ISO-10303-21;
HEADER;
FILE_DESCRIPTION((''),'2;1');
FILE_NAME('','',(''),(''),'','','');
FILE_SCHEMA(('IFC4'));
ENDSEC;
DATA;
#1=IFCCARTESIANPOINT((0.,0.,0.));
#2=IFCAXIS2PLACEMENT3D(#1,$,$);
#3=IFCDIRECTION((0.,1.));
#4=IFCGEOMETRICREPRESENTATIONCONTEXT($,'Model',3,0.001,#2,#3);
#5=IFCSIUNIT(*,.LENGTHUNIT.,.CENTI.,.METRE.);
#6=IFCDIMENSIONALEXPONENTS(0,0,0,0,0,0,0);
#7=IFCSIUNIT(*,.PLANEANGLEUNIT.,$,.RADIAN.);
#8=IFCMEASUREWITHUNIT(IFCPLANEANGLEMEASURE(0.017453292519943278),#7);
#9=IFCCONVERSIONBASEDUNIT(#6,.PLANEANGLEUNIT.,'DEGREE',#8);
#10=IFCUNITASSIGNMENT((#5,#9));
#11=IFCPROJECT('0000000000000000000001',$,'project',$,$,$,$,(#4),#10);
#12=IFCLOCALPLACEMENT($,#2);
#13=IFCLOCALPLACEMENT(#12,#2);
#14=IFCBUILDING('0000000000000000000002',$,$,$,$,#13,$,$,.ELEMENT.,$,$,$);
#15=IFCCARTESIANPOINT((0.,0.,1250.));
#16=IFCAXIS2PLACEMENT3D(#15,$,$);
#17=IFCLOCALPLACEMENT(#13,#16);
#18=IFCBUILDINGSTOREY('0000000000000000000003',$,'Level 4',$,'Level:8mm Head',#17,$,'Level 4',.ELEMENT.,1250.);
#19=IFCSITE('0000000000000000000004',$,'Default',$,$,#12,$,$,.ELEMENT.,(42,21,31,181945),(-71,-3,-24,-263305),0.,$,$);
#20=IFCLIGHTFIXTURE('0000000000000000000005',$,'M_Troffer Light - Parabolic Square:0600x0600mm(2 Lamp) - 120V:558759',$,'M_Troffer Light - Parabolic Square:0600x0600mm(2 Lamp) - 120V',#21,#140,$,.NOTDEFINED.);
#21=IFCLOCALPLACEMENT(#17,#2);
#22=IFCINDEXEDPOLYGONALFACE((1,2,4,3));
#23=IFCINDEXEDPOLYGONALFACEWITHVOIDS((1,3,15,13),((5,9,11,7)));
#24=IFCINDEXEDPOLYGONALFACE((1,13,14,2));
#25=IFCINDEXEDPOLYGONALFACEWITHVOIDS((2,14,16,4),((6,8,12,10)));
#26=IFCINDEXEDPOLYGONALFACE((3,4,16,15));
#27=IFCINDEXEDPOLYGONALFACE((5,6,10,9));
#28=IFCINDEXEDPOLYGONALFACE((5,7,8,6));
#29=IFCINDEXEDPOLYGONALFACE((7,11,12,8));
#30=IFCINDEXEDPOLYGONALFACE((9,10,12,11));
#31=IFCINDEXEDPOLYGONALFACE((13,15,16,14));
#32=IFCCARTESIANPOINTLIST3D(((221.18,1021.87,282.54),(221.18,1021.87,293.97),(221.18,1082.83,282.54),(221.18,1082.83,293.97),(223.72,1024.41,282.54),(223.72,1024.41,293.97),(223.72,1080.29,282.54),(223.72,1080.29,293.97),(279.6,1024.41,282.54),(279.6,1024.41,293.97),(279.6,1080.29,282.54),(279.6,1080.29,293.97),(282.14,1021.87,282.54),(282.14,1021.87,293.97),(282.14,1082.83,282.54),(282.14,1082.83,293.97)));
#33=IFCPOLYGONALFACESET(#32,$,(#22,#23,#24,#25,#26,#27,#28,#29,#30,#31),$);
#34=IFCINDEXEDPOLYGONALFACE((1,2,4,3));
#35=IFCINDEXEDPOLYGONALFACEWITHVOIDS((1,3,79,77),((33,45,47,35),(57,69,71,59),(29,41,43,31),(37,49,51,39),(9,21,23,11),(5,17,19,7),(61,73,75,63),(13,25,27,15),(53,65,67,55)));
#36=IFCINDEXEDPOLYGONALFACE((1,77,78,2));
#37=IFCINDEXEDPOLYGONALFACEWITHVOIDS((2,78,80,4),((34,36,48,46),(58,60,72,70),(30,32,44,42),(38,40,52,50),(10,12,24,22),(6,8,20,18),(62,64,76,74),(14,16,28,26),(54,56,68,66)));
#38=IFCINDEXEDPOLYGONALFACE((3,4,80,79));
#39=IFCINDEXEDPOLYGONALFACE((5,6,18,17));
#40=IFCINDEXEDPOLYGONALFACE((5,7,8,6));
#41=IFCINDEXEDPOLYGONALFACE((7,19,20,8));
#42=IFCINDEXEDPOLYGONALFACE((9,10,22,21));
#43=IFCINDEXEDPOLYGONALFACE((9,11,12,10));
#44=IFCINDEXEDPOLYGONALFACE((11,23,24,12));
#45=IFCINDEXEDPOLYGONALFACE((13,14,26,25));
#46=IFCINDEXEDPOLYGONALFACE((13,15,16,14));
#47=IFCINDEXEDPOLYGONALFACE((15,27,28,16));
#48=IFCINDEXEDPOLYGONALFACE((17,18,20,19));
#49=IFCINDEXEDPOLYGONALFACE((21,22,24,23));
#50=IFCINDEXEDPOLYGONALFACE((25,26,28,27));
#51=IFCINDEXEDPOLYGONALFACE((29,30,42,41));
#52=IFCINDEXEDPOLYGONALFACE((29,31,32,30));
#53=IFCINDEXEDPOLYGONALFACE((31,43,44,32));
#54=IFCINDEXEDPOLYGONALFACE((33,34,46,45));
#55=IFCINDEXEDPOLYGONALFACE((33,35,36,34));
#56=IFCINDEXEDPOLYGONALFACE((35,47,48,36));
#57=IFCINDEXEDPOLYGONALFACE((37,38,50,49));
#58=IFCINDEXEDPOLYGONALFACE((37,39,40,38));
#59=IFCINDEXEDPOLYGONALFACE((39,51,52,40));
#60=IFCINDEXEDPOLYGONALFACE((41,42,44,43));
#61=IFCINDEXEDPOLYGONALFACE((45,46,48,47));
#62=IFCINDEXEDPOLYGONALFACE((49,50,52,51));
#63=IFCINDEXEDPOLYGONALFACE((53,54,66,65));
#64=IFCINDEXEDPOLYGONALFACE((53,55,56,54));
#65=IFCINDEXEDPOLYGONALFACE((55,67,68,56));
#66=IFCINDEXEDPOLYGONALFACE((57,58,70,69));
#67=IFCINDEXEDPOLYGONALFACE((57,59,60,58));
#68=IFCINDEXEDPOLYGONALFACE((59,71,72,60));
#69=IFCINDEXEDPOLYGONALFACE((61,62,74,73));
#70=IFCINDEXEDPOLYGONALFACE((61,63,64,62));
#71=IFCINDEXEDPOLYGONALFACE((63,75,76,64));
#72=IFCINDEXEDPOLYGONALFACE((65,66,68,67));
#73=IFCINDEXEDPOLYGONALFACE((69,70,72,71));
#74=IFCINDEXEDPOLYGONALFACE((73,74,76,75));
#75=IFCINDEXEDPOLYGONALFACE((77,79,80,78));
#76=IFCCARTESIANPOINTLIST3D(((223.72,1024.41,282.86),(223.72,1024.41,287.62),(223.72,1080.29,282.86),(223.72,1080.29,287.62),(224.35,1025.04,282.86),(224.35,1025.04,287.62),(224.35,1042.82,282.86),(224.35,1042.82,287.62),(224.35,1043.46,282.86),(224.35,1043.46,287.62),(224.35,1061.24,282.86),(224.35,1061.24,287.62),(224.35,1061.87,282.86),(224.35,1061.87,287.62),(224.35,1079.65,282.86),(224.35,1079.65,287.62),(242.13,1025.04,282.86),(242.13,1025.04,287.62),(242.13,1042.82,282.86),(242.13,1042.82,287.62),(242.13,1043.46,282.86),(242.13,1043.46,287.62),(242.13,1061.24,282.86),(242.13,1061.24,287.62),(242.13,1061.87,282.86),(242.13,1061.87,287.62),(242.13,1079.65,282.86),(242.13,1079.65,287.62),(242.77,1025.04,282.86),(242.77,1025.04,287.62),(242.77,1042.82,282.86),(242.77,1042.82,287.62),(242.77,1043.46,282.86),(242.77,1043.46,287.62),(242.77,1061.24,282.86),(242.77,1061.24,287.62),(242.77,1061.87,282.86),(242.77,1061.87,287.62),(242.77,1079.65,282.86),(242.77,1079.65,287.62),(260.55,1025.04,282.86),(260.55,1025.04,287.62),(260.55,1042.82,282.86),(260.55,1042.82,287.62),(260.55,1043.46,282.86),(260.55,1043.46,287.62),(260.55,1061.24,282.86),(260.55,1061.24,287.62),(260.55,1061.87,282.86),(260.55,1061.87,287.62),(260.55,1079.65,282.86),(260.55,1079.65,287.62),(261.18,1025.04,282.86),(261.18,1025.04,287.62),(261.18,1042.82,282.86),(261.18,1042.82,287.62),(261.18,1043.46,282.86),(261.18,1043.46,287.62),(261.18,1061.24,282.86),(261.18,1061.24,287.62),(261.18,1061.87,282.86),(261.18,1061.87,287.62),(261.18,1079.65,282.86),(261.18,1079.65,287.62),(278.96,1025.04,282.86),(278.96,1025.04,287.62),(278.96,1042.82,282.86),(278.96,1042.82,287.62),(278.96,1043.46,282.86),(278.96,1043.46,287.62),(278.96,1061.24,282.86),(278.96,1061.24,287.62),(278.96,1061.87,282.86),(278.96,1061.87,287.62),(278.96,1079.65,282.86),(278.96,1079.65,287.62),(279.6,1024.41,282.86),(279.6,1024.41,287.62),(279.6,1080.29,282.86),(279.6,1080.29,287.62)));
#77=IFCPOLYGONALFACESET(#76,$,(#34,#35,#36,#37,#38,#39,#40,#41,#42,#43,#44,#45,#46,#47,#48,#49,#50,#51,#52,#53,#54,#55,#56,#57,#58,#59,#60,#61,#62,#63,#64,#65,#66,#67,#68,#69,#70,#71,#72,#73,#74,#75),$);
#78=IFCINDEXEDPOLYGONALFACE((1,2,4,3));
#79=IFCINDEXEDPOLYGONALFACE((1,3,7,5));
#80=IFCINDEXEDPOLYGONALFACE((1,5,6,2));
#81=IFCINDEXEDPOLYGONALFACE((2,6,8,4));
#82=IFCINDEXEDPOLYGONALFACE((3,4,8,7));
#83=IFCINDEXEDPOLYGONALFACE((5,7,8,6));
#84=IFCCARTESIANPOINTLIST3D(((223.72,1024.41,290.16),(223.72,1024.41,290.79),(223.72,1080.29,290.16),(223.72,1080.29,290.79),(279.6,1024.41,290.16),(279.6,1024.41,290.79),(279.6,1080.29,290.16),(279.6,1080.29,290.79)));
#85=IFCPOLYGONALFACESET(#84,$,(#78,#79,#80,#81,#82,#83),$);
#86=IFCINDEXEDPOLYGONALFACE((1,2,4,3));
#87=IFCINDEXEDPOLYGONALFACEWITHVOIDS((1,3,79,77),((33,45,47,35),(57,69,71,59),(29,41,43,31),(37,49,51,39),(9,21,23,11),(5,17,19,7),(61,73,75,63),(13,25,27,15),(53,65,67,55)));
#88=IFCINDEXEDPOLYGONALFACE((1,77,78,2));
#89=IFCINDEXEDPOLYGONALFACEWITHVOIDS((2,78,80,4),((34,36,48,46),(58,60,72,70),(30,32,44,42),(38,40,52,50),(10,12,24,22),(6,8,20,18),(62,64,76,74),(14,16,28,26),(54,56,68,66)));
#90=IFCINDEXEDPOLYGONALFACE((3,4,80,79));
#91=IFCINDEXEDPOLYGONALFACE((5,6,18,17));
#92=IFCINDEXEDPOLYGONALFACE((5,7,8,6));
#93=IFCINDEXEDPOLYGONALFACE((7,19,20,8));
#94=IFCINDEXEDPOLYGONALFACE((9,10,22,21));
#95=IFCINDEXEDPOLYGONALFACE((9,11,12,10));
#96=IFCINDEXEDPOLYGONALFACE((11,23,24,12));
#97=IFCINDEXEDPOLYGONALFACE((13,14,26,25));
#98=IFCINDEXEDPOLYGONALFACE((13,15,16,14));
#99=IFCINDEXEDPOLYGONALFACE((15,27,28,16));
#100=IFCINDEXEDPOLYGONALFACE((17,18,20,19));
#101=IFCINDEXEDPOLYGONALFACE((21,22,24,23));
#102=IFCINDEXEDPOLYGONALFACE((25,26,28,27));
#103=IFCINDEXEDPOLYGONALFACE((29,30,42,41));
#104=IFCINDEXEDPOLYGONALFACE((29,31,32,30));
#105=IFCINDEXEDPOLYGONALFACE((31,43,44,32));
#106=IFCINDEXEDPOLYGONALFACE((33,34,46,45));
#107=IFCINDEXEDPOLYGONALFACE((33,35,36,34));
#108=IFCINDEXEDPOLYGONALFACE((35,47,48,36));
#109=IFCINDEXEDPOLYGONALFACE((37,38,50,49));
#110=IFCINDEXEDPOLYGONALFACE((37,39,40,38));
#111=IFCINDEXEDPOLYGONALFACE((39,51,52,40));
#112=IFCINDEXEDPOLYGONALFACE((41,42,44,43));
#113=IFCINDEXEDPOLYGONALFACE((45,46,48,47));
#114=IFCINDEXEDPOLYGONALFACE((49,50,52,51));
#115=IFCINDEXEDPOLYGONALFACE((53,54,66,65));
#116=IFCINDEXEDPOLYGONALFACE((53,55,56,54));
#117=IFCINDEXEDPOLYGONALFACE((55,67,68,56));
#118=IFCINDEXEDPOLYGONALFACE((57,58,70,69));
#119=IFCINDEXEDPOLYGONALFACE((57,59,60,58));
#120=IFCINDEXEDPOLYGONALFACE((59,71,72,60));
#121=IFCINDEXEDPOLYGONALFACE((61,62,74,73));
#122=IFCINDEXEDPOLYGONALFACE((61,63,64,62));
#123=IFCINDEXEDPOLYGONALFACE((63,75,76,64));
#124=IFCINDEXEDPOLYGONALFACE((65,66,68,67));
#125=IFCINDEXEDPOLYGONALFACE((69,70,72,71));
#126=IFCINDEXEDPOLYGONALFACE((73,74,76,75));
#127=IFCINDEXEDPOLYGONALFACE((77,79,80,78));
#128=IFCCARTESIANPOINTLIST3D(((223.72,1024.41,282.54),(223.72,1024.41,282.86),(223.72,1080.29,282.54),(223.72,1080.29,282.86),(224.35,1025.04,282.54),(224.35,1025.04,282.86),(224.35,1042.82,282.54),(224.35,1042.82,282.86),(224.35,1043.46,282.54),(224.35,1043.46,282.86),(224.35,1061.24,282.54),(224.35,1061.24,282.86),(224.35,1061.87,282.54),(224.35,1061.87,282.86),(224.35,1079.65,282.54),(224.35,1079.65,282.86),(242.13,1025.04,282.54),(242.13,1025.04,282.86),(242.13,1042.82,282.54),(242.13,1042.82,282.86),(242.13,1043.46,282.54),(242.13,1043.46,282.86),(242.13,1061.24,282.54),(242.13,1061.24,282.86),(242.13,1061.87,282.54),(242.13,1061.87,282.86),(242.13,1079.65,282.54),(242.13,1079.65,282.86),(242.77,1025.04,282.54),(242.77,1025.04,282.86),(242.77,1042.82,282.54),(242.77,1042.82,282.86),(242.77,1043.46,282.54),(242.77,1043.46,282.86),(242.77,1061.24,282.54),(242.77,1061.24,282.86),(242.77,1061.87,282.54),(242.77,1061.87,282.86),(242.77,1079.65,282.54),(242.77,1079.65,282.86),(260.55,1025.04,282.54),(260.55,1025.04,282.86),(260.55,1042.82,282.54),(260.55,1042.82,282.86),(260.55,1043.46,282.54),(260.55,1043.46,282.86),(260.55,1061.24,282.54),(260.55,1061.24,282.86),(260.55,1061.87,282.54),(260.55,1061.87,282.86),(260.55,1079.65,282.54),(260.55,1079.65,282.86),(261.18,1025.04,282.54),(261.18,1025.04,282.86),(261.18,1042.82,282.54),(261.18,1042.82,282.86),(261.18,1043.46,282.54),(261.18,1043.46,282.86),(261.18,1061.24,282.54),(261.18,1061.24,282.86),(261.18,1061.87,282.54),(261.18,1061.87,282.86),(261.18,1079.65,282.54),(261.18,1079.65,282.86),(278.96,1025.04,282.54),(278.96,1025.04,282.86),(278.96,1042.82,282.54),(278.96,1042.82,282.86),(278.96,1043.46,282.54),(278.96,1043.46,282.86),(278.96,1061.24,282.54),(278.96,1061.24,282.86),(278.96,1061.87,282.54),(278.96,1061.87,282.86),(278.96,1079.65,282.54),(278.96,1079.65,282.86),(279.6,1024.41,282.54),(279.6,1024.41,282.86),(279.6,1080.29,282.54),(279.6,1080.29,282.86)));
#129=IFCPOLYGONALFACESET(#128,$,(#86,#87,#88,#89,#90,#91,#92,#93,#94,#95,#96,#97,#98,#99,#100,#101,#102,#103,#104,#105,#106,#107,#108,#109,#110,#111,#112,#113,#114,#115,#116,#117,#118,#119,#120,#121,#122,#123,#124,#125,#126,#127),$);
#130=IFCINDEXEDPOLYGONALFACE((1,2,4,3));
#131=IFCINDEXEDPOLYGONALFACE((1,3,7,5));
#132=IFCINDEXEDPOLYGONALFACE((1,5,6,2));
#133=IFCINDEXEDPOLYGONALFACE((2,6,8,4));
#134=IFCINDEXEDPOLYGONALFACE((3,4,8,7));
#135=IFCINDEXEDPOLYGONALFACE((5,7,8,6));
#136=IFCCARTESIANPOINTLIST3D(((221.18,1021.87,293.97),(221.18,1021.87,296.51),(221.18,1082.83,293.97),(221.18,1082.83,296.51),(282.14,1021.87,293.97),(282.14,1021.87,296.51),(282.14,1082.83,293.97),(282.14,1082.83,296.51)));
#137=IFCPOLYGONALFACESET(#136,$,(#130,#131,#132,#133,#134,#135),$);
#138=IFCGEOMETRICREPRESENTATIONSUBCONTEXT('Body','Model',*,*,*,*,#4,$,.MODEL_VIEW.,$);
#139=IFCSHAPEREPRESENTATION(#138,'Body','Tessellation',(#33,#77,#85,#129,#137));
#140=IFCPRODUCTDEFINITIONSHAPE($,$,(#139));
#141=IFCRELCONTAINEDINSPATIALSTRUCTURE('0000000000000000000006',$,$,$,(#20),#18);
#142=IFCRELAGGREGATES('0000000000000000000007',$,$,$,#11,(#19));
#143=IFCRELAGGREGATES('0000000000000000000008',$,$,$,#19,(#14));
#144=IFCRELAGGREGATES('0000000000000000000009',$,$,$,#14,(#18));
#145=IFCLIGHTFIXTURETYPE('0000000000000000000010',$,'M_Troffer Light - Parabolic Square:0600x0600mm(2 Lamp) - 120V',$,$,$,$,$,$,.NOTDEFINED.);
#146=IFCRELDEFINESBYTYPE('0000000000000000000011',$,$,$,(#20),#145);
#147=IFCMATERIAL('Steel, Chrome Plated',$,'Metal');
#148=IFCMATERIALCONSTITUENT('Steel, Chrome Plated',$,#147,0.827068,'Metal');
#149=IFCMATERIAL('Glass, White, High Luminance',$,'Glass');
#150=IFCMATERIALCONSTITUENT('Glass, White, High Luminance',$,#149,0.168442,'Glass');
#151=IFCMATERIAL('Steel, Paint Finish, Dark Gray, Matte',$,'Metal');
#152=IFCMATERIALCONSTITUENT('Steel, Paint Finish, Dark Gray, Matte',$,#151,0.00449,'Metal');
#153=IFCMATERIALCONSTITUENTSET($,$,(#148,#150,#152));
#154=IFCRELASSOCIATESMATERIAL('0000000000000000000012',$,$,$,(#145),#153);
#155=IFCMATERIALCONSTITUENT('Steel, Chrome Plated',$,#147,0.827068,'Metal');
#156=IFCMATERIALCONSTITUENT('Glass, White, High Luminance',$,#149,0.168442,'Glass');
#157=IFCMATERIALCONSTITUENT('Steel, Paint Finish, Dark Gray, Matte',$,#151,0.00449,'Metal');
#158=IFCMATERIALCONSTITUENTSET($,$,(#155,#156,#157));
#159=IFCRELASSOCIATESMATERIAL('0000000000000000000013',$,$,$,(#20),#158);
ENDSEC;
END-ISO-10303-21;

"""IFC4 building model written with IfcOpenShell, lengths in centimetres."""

from ifc_helpers import new_model, entity, si_unit, converted_unit, direction, frame, origin, place, context, subcontext, project, spatial, indexed_curve, outline, extrude, source, transform, mapped, material, constituent, constituent_set, type_object, type_shapes, element, save


model = new_model("IFC4")

# Units and contexts
model_context = context("Model", 3, precision=0.001, world=origin(), true_north=direction((0.0, 1.0)))
body_context = subcontext(model_context, "Body", "Model", "MODEL_VIEW")
ifc_project = project(units=[si_unit("LENGTHUNIT", "METRE", prefix="CENTI"), converted_unit("PLANEANGLEUNIT", "DEGREE", entity("IfcPlaneAngleMeasure", 0.017453292519943278), si_unit("PLANEANGLEUNIT", "RADIAN"), dimensions=[0, 0, 0, 0, 0, 0, 0])], contexts=[model_context])

# Site, building, storey
site_placement = place(None, origin())
site = spatial("IfcSite", under=ifc_project, at=site_placement, Name="Default", CompositionType="ELEMENT", RefLatitude=(42, 21, 31, 181945), RefLongitude=(-71, -3, -24, -263305), RefElevation=0.0)
building_placement = place(site_placement, origin())
building = spatial("IfcBuilding", under=site, at=building_placement, CompositionType="ELEMENT")
storey_placement = place(building_placement, frame((0.0, 0.0, 1250.0)))
storey = spatial("IfcBuildingStorey", under=building, at=storey_placement, Name="Level 4", ObjectType="Level:8mm Head", LongName="Level 4", CompositionType="ELEMENT", Elevation=1250.0)

# Light fixture
ifc_material_1 = material(Name="Steel, Chrome Plated", Category="Metal")
ifc_material_2 = material(Name="Glass, White, High Luminance", Category="Glass")
ifc_material_3 = material(Name="Steel, Paint Finish, Dark Gray, Matte", Category="Metal")
ifc_constituent_1 = constituent(ifc_material_1, Name="Steel, Chrome Plated", Category="Metal", fraction=0.827068)
ifc_constituent_2 = constituent(ifc_material_2, Name="Glass, White, High Luminance", Category="Glass", fraction=0.168442)
ifc_constituent_3 = constituent(ifc_material_3, Name="Steel, Paint Finish, Dark Gray, Matte", Category="Metal", fraction=0.00449)
ifc_constituent_set_1 = constituent_set(constituents=[ifc_constituent_1, ifc_constituent_2, ifc_constituent_3])
light_fixture_type_1 = type_object("IfcLightFixtureType", Name="M_Troffer Light - Parabolic Square:0600x0600mm(2 Lamp) - 120V", PredefinedType="NOTDEFINED", material=ifc_constituent_set_1)
shared_shape_1 = source(origin(), body_context, "Body", "SweptSolid", [
    extrude(outline(indexed_curve([(-30.48, -30.48), (30.48, -30.48), (30.48, 30.48), (-30.48, 30.48), (-30.48, -30.48)], self_intersect=False), holes=[indexed_curve([(-27.94, -27.94), (-27.94, 27.94), (27.94, 27.94), (27.94, -27.94), (-27.94, -27.94)], self_intersect=False)]), frame((-1.87, -5.95, 243.84), z_axis=(0.0, 0.0, 1.0), x_axis=(-1.0, 0.0, 0.0)), (0.0, 0.0, 1.0), 11.43),
    extrude(outline(indexed_curve([(-27.94, -27.94), (27.94, -27.94), (27.94, 27.94), (-27.94, 27.94), (-27.94, -27.94)], self_intersect=False), holes=[indexed_curve([(9.52, -9.52), (27.31, -9.52), (27.31, -27.3), (9.52, -27.3), (9.52, -9.52)], self_intersect=False), indexed_curve([(9.52, 8.89), (27.3, 8.89), (27.3, -8.89), (9.52, -8.89), (9.52, 8.89)], self_intersect=False), indexed_curve([(9.52, 9.53), (9.52, 27.31), (27.3, 27.31), (27.3, 9.53), (9.52, 9.53)], self_intersect=False), indexed_curve([(-8.89, -9.52), (8.89, -9.52), (8.89, -27.3), (-8.89, -27.3), (-8.89, -9.52)], self_intersect=False), indexed_curve([(-8.89, 8.89), (8.89, 8.89), (8.89, -8.89), (-8.89, -8.89), (-8.89, 8.89)], self_intersect=False), indexed_curve([(-8.89, 9.53), (-8.89, 27.31), (8.89, 27.31), (8.89, 9.53), (-8.89, 9.53)], self_intersect=False), indexed_curve([(-27.31, -9.52), (-9.53, -9.52), (-9.53, -27.31), (-27.31, -27.31), (-27.31, -9.52)], self_intersect=False), indexed_curve([(-27.31, 8.89), (-9.52, 8.89), (-9.52, -8.89), (-27.31, -8.89), (-27.31, 8.89)], self_intersect=False), indexed_curve([(-27.31, 9.53), (-27.31, 27.31), (-9.52, 27.31), (-9.52, 9.53), (-27.31, 9.53)], self_intersect=False)]), frame((-1.87, -5.95, 244.16), z_axis=(0.0, 0.0, 1.0), x_axis=(-1.0, 0.0, 0.0)), (0.0, 0.0, 1.0), 4.76),
    extrude(outline(indexed_curve([(-27.94, -27.94), (27.94, -27.94), (27.94, 27.94), (-27.94, 27.94), (-27.94, -27.94)], self_intersect=False)), frame((-1.87, -5.95, 251.46), z_axis=(0.0, 0.0, 1.0), x_axis=(-1.0, 0.0, 0.0)), (0.0, 0.0, 1.0), 0.64),
    extrude(outline(indexed_curve([(-27.94, -27.94), (27.94, -27.94), (27.94, 27.94), (-27.94, 27.94), (-27.94, -27.94)], self_intersect=False), holes=[indexed_curve([(9.52, -9.52), (27.31, -9.52), (27.31, -27.3), (9.52, -27.3), (9.52, -9.52)], self_intersect=False), indexed_curve([(9.52, 8.89), (27.3, 8.89), (27.3, -8.89), (9.52, -8.89), (9.52, 8.89)], self_intersect=False), indexed_curve([(9.52, 9.53), (9.52, 27.31), (27.3, 27.31), (27.3, 9.53), (9.52, 9.53)], self_intersect=False), indexed_curve([(-8.89, -9.52), (8.89, -9.52), (8.89, -27.3), (-8.89, -27.3), (-8.89, -9.52)], self_intersect=False), indexed_curve([(-8.89, 8.89), (8.89, 8.89), (8.89, -8.89), (-8.89, -8.89), (-8.89, 8.89)], self_intersect=False), indexed_curve([(-8.89, 9.53), (-8.89, 27.31), (8.89, 27.31), (8.89, 9.53), (-8.89, 9.53)], self_intersect=False), indexed_curve([(-27.31, -9.52), (-9.53, -9.52), (-9.53, -27.31), (-27.31, -27.31), (-27.31, -9.52)], self_intersect=False), indexed_curve([(-27.31, 8.89), (-9.52, 8.89), (-9.52, -8.89), (-27.31, -8.89), (-27.31, 8.89)], self_intersect=False), indexed_curve([(-27.31, 9.53), (-27.31, 27.31), (-9.52, 27.31), (-9.52, 9.53), (-27.31, 9.53)], self_intersect=False)]), frame((-1.87, -5.95, 243.84), z_axis=(0.0, 0.0, 1.0), x_axis=(-1.0, 0.0, 0.0)), (0.0, 0.0, 1.0), 0.32),
    extrude(outline(indexed_curve([(-30.48, -30.48), (30.48, -30.48), (30.48, 30.48), (-30.48, 30.48), (-30.48, -30.48)], self_intersect=False)), frame((-1.87, -5.95, 255.27), z_axis=(0.0, 0.0, 1.0), x_axis=(-1.0, 0.0, 0.0)), (0.0, 0.0, 1.0), 2.54),
])
type_shapes(light_fixture_type_1, [shared_shape_1])
ifc_constituent_4 = constituent(ifc_material_1, Name="Steel, Chrome Plated", Category="Metal", fraction=0.827068)
ifc_constituent_5 = constituent(ifc_material_2, Name="Glass, White, High Luminance", Category="Glass", fraction=0.168442)
ifc_constituent_6 = constituent(ifc_material_3, Name="Steel, Paint Finish, Dark Gray, Matte", Category="Metal", fraction=0.00449)
ifc_constituent_set_2 = constituent_set(constituents=[ifc_constituent_4, ifc_constituent_5, ifc_constituent_6])
light_fixture_1_placement = place(storey_placement, frame((253.53, 1058.29, 38.7)))
element("IfcLightFixture", 1, at=light_fixture_1_placement, inside=storey, type_object=light_fixture_type_1, material=ifc_constituent_set_2, Name="M_Troffer Light - Parabolic Square:0600x0600mm(2 Lamp) - 120V:558759", ObjectType="M_Troffer Light - Parabolic Square:0600x0600mm(2 Lamp) - 120V", PredefinedType="NOTDEFINED", context=body_context, shape_type="MappedRepresentation", body=[
    mapped(shared_shape_1, transform((0.0, 0.0, 0.0), scale=1.0)),
])

save(model, "model.ifc")
